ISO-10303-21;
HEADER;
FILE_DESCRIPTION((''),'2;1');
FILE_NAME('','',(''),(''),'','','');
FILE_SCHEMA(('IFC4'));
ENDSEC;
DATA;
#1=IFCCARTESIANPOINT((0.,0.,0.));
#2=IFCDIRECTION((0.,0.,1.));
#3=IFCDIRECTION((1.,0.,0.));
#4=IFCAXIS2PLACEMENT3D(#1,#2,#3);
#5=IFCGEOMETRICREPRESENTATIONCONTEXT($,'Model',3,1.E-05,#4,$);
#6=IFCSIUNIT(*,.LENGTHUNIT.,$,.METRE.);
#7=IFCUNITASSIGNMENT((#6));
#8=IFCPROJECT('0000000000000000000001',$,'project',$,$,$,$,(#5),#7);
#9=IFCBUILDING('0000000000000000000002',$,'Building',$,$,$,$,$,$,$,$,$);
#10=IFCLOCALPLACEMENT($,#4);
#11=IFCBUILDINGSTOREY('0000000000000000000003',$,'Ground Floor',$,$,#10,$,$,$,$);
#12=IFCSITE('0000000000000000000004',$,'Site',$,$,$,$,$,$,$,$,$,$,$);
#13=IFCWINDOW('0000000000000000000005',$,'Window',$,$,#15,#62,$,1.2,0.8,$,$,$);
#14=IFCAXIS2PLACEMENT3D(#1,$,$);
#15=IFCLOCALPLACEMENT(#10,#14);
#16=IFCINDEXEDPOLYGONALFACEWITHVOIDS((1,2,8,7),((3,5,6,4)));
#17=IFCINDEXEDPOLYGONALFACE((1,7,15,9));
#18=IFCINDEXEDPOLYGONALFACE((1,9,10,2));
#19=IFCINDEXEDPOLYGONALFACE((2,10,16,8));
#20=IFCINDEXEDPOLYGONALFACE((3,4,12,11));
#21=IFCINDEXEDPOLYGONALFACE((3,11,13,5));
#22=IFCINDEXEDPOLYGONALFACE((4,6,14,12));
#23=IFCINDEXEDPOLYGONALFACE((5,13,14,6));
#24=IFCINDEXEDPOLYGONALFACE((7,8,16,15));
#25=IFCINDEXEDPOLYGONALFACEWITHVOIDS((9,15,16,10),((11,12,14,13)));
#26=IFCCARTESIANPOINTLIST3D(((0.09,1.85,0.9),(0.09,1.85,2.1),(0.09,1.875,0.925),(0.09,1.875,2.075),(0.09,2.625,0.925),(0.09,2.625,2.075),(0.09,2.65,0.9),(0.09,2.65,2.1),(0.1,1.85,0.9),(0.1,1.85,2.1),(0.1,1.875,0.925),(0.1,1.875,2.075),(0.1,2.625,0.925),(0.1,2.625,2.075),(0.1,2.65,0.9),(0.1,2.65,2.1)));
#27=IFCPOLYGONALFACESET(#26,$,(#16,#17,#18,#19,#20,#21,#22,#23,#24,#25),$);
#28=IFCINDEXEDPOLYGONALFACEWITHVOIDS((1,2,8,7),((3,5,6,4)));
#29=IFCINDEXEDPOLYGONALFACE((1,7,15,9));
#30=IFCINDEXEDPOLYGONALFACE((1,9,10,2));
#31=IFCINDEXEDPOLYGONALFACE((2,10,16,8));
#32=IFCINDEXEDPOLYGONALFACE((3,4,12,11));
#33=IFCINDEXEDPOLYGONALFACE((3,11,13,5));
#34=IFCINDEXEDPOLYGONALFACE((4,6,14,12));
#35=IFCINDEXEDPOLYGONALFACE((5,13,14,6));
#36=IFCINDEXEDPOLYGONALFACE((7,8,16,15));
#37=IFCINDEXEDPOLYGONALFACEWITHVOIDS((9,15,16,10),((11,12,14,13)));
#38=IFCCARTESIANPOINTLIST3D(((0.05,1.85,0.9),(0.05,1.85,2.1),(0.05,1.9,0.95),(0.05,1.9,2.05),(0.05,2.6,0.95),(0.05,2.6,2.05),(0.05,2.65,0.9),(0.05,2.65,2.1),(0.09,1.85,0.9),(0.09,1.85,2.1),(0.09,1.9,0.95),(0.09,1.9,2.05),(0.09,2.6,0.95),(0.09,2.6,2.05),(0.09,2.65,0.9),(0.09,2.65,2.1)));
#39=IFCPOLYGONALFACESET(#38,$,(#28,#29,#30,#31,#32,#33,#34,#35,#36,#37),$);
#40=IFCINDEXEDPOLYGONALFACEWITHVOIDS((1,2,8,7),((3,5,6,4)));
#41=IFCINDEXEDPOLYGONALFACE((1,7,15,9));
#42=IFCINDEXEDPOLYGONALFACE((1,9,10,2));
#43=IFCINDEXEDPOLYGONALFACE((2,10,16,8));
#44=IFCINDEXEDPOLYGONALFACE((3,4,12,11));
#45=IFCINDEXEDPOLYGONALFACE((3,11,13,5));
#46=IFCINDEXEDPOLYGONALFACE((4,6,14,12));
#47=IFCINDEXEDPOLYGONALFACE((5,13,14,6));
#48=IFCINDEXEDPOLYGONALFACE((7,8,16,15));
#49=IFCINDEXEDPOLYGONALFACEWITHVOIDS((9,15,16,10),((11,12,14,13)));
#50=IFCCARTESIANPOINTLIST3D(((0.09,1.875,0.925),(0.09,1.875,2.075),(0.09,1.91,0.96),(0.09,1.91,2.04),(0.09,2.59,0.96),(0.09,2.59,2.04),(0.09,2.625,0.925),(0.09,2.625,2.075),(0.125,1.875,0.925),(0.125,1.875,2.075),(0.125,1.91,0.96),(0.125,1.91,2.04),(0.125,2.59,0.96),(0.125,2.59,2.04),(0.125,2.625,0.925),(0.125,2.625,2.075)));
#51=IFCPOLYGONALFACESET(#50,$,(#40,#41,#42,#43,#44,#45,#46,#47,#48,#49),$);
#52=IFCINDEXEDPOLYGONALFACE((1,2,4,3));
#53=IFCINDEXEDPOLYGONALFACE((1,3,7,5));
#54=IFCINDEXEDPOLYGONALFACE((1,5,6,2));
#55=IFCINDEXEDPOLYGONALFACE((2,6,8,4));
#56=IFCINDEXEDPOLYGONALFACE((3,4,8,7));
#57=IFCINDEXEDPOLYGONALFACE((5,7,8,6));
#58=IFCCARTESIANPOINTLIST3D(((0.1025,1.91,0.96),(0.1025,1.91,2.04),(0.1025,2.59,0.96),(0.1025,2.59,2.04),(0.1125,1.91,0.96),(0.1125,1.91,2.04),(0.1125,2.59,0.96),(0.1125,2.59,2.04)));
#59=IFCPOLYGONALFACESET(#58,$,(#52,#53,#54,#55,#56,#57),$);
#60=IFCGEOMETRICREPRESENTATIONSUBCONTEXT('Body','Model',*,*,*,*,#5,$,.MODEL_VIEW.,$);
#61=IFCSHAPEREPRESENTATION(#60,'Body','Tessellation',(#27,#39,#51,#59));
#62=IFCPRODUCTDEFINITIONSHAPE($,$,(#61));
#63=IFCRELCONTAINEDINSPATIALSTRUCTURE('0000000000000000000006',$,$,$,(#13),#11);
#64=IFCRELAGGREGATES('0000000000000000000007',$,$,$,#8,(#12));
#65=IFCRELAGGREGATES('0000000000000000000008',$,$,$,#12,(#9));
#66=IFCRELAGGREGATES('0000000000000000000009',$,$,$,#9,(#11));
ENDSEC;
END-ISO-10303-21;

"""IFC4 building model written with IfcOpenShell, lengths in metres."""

from ifc_helpers import new_model, si_unit, frame, origin_with_axes, place, context, subcontext, project, spatial, line, indexed_curve, outline, extrude, element, save


model = new_model("IFC4")

# Units and contexts
model_context = context("Model", 3, precision=1e-05, world=origin_with_axes())
body_context = subcontext(model_context, "Body", "Model", "MODEL_VIEW")
ifc_project = project(units=[si_unit("LENGTHUNIT", "METRE")], contexts=[model_context])

# Site, building, storey
site = spatial("IfcSite", under=ifc_project, Name="Site")
building = spatial("IfcBuilding", under=site, Name="Building")
storey_placement = place(None, origin_with_axes())
storey = spatial("IfcBuildingStorey", under=building, at=storey_placement, Name="Ground Floor")

# Window
window_1_placement = place(storey_placement, frame((0.0, 2.65, 0.9), z_axis=(0.0, 0.0, 1.0), x_axis=(0.0, -1.0, 0.0)))
element("IfcWindow", 1, at=window_1_placement, inside=storey, Name="Window", OverallHeight=1.2, OverallWidth=0.8, context=body_context, shape_type="SweptSolid", body=[
    extrude(outline(indexed_curve([(0.0, 0.0), (0.8, 0.0), (0.8, 1.2), (0.0, 1.2)], segments=[line(1, 2, 3, 4, 1)]), holes=[indexed_curve([(0.025, 0.025), (0.775, 0.025), (0.775, 1.175), (0.025, 1.175)], segments=[line(1, 2, 3, 4, 1)])]), frame((0.0, 0.09, 0.0), z_axis=(0.0, -1.0, 0.0), x_axis=(1.0, 0.0, 0.0)), (0.0, 0.0, -1.0), 0.01),
    extrude(outline(indexed_curve([(0.0, 0.0), (0.8, 0.0), (0.8, 1.2), (0.0, 1.2)], segments=[line(1, 2, 3, 4, 1)]), holes=[indexed_curve([(0.05, 0.05), (0.75, 0.05), (0.75, 1.15), (0.05, 1.15)], segments=[line(1, 2, 3, 4, 1)])]), frame((0.0, 0.05, 0.0), z_axis=(0.0, -1.0, 0.0), x_axis=(1.0, 0.0, 0.0)), (0.0, 0.0, -1.0), 0.04),
    extrude(outline(indexed_curve([(0.0, 0.0), (0.75, 0.0), (0.75, 1.15), (0.0, 1.15)], segments=[line(1, 2, 3, 4, 1)]), holes=[indexed_curve([(0.035, 0.035), (0.715, 0.035), (0.715, 1.115), (0.035, 1.115)], segments=[line(1, 2, 3, 4, 1)])]), frame((0.025, 0.09, 0.025), z_axis=(0.0, -1.0, 0.0), x_axis=(1.0, 0.0, 0.0)), (0.0, 0.0, -1.0), 0.035),
    extrude(outline(indexed_curve([(0.035, 0.035), (0.715, 0.035), (0.715, 1.115), (0.035, 1.115)], segments=[line(1, 2, 3, 4, 1)])), frame((0.025, 0.1025, 0.025), z_axis=(0.0, -1.0, 0.0), x_axis=(1.0, 0.0, 0.0)), (0.0, 0.0, -1.0), 0.01),
])

save(model, "model.ifc")
